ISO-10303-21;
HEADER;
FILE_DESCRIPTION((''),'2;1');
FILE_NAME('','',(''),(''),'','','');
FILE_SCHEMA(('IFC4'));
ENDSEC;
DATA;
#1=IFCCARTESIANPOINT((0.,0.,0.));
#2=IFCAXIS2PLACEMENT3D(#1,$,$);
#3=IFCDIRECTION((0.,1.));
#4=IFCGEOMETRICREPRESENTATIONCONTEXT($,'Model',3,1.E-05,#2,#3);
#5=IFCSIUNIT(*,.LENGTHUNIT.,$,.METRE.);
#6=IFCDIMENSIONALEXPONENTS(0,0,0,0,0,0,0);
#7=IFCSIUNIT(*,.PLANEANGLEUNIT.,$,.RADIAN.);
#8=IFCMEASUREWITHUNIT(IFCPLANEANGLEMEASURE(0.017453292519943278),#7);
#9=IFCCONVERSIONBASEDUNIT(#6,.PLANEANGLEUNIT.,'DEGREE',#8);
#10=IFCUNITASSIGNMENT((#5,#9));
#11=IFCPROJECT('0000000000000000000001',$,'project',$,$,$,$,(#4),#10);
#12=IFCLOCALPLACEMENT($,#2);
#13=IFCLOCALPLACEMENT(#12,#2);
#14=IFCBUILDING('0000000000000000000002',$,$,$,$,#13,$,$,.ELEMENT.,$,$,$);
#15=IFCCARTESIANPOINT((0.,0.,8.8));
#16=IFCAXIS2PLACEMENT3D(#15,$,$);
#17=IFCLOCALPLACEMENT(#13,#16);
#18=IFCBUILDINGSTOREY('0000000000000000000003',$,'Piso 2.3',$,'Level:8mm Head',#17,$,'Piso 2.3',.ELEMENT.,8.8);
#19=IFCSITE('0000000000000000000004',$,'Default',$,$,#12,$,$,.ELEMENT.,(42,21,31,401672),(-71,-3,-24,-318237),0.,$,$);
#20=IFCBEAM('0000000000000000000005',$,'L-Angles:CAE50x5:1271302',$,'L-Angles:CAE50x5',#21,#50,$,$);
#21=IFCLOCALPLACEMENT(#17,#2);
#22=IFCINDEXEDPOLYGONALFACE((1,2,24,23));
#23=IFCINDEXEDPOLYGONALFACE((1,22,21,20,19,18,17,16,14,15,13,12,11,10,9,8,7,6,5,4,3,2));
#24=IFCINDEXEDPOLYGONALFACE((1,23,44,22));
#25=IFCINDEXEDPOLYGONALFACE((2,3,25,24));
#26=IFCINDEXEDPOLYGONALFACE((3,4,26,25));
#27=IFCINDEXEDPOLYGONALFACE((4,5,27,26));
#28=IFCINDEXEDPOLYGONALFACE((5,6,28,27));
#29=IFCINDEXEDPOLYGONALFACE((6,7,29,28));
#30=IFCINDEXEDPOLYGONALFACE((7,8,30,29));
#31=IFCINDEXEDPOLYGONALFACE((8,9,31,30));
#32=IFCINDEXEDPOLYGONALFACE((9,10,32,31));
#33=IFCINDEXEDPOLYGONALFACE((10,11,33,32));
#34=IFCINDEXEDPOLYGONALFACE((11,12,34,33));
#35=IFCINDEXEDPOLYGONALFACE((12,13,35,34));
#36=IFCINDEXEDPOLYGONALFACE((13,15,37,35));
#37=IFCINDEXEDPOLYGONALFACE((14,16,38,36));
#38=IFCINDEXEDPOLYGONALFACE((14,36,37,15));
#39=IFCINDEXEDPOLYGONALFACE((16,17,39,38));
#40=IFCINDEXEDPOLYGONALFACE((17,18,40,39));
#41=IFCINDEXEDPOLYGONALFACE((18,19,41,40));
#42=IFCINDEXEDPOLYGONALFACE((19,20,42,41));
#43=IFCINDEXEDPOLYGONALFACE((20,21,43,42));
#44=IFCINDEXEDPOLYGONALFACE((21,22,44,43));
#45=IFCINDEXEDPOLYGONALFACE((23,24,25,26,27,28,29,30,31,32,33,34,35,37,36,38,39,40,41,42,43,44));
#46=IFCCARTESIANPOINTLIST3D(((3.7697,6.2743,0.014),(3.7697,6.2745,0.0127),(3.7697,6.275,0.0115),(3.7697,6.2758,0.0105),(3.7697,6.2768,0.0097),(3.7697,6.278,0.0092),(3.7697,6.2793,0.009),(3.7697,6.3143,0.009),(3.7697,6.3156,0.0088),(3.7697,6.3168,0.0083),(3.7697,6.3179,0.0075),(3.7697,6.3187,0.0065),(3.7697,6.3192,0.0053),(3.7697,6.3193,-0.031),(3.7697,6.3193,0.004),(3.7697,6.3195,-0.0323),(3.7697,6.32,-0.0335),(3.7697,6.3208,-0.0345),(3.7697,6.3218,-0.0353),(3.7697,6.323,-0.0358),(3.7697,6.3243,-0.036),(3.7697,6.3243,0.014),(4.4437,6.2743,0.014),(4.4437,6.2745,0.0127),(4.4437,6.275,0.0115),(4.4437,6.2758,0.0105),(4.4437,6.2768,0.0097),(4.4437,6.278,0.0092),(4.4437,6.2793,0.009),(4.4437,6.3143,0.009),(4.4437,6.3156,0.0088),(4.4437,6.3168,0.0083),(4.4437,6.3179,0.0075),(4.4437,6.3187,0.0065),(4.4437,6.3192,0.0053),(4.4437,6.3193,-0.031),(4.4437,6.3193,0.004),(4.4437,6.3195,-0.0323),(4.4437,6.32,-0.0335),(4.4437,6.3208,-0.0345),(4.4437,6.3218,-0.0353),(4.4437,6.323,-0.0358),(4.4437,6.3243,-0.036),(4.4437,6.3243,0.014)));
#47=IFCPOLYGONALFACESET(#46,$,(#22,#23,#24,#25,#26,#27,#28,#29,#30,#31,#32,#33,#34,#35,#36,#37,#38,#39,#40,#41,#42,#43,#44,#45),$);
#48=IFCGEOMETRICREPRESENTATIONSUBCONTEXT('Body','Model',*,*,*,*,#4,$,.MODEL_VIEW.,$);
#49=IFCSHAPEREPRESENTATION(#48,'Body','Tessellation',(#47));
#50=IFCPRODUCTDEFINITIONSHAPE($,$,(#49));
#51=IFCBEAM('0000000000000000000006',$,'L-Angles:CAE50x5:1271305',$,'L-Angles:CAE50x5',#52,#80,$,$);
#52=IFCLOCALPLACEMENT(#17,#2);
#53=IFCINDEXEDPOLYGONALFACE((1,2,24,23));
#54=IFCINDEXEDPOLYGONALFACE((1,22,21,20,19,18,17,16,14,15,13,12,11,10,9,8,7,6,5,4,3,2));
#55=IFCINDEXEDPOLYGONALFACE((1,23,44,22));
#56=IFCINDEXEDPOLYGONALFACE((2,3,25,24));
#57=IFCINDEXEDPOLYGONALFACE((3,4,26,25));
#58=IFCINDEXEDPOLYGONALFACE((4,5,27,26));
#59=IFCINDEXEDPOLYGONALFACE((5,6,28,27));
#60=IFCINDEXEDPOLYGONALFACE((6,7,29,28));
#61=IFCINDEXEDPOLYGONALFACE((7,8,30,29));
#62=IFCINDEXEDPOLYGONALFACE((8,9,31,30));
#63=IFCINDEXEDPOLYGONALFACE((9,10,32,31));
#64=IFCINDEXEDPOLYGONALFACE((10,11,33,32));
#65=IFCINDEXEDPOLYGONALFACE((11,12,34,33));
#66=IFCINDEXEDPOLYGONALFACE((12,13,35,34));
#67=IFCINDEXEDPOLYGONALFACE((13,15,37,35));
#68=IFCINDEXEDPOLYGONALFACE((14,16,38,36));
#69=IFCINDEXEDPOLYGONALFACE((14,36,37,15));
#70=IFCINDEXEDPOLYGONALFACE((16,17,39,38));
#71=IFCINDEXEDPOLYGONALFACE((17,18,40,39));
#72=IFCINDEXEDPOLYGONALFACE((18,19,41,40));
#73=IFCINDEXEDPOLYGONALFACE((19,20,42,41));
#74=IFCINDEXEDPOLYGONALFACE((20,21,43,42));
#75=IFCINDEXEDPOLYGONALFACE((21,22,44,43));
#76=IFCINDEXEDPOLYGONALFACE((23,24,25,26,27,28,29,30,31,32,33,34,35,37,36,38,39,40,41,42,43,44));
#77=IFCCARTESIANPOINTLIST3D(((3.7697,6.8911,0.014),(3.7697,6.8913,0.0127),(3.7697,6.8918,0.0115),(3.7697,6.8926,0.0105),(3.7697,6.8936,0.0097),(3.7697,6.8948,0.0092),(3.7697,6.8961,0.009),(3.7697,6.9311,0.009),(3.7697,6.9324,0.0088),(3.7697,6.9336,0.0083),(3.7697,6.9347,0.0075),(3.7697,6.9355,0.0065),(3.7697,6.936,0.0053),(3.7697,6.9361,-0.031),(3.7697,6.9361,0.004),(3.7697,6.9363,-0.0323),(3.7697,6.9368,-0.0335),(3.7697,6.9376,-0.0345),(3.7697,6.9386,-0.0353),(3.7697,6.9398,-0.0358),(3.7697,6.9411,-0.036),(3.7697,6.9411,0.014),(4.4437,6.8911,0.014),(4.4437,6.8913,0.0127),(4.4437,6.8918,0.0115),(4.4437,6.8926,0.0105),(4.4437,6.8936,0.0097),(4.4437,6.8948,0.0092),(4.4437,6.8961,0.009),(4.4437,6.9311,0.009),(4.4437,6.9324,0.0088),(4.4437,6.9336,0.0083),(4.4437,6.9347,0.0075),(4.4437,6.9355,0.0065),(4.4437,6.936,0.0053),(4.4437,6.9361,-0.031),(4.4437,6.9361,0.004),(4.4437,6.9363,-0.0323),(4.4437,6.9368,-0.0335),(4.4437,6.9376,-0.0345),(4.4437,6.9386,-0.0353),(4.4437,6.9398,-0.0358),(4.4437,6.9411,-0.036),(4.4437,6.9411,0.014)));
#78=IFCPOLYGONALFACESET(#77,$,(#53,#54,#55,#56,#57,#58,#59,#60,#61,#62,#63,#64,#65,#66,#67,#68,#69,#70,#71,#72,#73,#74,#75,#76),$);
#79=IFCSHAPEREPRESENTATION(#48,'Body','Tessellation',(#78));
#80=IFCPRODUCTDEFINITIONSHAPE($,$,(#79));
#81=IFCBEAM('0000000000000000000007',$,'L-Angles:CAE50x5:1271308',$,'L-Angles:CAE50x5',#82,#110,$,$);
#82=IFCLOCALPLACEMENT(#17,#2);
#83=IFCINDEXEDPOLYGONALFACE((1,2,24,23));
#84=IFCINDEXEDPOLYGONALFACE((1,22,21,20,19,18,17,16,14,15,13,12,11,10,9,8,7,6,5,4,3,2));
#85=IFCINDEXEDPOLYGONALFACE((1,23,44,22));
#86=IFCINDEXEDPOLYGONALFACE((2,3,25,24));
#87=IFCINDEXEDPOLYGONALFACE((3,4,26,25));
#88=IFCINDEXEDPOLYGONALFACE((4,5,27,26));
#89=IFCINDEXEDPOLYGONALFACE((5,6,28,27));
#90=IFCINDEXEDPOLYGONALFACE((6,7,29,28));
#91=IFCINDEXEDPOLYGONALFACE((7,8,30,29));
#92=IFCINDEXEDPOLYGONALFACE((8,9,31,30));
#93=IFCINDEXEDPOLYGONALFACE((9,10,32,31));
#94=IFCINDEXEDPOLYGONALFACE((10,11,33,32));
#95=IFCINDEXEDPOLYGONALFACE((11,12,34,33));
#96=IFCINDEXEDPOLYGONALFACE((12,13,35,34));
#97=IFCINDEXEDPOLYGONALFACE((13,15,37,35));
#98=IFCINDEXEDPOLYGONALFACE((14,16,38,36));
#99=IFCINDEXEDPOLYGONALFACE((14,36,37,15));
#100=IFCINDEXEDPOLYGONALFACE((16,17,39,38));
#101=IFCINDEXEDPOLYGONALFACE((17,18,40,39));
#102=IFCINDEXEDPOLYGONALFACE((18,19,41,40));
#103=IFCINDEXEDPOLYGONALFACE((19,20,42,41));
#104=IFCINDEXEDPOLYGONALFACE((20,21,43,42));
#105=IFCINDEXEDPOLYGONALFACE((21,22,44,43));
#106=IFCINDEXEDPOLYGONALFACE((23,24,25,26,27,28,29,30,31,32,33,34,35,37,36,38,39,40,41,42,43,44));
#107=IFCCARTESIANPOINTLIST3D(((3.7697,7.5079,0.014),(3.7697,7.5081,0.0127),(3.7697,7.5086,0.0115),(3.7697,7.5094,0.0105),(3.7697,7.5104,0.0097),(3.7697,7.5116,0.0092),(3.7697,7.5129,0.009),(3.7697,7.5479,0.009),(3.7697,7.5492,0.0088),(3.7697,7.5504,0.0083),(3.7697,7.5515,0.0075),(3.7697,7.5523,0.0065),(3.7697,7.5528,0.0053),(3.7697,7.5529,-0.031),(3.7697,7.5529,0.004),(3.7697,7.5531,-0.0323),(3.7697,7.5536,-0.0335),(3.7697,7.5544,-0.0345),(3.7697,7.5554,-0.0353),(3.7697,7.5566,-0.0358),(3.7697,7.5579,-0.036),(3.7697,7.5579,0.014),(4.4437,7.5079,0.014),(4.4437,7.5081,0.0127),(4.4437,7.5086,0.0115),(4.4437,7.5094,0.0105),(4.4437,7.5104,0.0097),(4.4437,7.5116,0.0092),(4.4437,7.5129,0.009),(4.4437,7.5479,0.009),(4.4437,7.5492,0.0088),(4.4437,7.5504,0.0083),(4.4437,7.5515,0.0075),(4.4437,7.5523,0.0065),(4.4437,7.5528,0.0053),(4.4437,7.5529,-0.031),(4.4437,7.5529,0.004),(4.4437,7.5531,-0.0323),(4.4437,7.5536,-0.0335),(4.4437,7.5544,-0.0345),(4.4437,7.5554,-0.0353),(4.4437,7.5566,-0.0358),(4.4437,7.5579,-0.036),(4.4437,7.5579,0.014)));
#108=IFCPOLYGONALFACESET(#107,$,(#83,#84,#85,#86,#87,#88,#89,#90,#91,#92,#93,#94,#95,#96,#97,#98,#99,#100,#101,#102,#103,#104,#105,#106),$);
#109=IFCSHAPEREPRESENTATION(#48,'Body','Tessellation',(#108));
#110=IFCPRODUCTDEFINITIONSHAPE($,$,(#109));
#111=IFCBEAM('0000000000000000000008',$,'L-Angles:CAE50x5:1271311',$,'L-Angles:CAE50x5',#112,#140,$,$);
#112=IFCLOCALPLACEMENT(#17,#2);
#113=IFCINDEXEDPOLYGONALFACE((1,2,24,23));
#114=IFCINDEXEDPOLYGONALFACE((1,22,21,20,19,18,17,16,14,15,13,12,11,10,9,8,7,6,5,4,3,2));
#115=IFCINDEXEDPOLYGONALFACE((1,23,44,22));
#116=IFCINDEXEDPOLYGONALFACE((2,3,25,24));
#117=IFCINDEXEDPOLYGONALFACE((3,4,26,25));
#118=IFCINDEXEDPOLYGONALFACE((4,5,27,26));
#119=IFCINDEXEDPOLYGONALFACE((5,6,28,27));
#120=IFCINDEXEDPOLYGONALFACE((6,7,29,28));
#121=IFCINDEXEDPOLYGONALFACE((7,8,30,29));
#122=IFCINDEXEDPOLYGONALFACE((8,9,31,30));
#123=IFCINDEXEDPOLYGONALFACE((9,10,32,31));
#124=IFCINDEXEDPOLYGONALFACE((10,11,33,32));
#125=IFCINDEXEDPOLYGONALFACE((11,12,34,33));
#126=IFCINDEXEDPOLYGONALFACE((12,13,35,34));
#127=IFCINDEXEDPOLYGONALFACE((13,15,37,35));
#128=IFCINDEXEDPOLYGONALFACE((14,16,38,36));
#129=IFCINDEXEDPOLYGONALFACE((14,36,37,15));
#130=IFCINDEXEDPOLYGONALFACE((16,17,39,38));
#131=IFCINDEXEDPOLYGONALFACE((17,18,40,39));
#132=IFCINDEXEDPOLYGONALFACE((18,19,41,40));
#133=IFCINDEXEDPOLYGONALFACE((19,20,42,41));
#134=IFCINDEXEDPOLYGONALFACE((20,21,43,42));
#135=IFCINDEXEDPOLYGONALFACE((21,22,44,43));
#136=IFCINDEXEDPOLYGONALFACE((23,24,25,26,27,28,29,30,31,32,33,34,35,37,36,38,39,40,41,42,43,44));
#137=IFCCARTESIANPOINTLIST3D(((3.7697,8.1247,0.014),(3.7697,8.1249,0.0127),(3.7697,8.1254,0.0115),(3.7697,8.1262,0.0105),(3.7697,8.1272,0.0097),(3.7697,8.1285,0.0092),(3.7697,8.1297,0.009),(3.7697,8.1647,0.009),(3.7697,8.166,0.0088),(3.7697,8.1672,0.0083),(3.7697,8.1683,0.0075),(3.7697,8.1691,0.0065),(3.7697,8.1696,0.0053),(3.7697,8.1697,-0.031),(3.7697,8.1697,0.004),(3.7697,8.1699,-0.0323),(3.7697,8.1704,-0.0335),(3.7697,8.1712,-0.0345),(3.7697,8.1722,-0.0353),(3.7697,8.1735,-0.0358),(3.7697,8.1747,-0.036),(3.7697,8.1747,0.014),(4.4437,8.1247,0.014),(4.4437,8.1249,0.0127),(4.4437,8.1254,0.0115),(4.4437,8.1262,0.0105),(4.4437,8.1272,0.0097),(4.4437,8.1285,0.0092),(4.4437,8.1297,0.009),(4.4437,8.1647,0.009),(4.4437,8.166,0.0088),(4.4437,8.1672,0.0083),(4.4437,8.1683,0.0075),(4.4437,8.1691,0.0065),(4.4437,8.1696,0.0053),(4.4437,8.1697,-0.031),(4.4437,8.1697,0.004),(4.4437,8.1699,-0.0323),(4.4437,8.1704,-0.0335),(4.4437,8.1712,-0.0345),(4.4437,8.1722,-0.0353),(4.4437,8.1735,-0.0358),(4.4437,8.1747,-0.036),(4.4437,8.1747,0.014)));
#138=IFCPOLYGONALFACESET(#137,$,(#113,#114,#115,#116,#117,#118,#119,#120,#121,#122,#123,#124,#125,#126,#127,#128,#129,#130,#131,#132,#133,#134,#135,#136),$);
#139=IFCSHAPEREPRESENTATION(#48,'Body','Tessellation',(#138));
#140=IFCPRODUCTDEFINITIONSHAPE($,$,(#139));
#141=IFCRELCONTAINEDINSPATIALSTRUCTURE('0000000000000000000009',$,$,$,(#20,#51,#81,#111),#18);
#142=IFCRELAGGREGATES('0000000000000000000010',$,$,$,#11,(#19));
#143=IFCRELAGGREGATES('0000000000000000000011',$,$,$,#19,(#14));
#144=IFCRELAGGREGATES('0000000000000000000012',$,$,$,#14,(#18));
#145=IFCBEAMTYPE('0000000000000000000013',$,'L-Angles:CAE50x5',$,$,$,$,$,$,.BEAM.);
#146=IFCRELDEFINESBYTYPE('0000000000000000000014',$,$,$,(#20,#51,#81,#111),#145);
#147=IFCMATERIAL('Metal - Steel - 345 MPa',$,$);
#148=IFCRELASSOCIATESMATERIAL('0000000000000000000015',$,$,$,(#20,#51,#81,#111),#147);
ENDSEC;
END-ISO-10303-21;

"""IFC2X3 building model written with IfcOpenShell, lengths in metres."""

from ifc_helpers import new_model, entity, si_unit, converted_unit, direction, frame, frame_2d, origin, place, context, subcontext, project, spatial, polyline, circle_curve, parameter, trimmed, segment, composite_curve, outline, extrude, material, type_object, element, save


model = new_model("IFC2X3")

# Units and contexts
model_context = context("Model", 3, precision=1e-05, world=origin(), true_north=direction((0.0, 1.0)))
body_context = subcontext(model_context, "Body", "Model", "MODEL_VIEW")
ifc_project = project(units=[si_unit("LENGTHUNIT", "METRE"), converted_unit("PLANEANGLEUNIT", "DEGREE", entity("IfcPlaneAngleMeasure", 0.017453292519943278), si_unit("PLANEANGLEUNIT", "RADIAN"), dimensions=[0, 0, 0, 0, 0, 0, 0])], contexts=[model_context])

# Site, building, storey
site_placement = place(None, origin())
site = spatial("IfcSite", under=ifc_project, at=site_placement, Name="Default", CompositionType="ELEMENT", RefLatitude=(42, 21, 31, 401672), RefLongitude=(-71, -3, -24, -318237), RefElevation=0.0)
building_placement = place(site_placement, origin())
building = spatial("IfcBuilding", under=site, at=building_placement, CompositionType="ELEMENT")
storey_placement = place(building_placement, frame((0.0, 0.0, 8.8)))
storey = spatial("IfcBuildingStorey", under=building, at=storey_placement, Name="Piso 2.3", ObjectType="Level:8mm Head", LongName="Piso 2.3", CompositionType="ELEMENT", Elevation=8.8)

# Shared definitions
ifc_material = material(Name="Metal - Steel - 345 MPa")

# Beams
beam_type_1 = type_object("IfcBeamType", Name="L-Angles:CAE50x5", PredefinedType="BEAM")
beam_1_placement = place(storey_placement, frame((3.7067, 6.3103, 0.0)))
element("IfcBeam", 1, at=beam_1_placement, inside=storey, type_object=beam_type_1, material=ifc_material, Name="L-Angles:CAE50x5:1271302", ObjectType="L-Angles:CAE50x5", context=body_context, shape_type="SweptSolid", body=[
    extrude(outline(composite_curve([segment(polyline([(-0.0336, -0.0164), (0.0164, -0.0164)]), True, "CONTINUOUS"), segment(polyline([(0.0164, -0.0164), (0.0164, 0.0336)]), True, "CONTINUOUS"), segment(trimmed(circle_curve(frame_2d((0.0164, 0.0286), x_axis=(0.0, 1.0)), 0.005), [parameter(0.0)], [parameter(90.0)], True, "PARAMETER"), True, "CONTINUOUS"), segment(polyline([(0.0114, 0.0286), (0.0114, -0.0064)]), True, "CONTINUOUS"), segment(trimmed(circle_curve(frame_2d((0.0064, -0.0064), x_axis=(1.0, 0.0)), 0.005), [parameter(270.0)], [parameter(0.0)], True, "PARAMETER"), False, "CONTINUOUS"), segment(polyline([(0.0064, -0.0114), (-0.0286, -0.0114)]), True, "CONTINUOUS"), segment(trimmed(circle_curve(frame_2d((-0.0286, -0.0164), x_axis=(0.0, 1.0)), 0.005), [parameter(0.0)], [parameter(90.0)], True, "PARAMETER"), True, "CONTINUOUS")], self_intersect=False)), frame((0.063, -0.0024, -0.0024), z_axis=(1.0, 0.0, 0.0), x_axis=(0.0, 0.0, 1.0)), (0.0, 0.0, 1.0), 0.674),
])
beam_2_placement = place(storey_placement, frame((3.7067, 6.9271, 0.0)))
element("IfcBeam", 2, at=beam_2_placement, inside=storey, type_object=beam_type_1, material=ifc_material, Name="L-Angles:CAE50x5:1271305", ObjectType="L-Angles:CAE50x5", context=body_context, shape_type="SweptSolid", body=[
    extrude(outline(composite_curve([segment(polyline([(-0.0336, -0.0164), (0.0164, -0.0164)]), True, "CONTINUOUS"), segment(polyline([(0.0164, -0.0164), (0.0164, 0.0336)]), True, "CONTINUOUS"), segment(trimmed(circle_curve(frame_2d((0.0164, 0.0286), x_axis=(0.0, 1.0)), 0.005), [parameter(0.0)], [parameter(90.0)], True, "PARAMETER"), True, "CONTINUOUS"), segment(polyline([(0.0114, 0.0286), (0.0114, -0.0064)]), True, "CONTINUOUS"), segment(trimmed(circle_curve(frame_2d((0.0064, -0.0064), x_axis=(1.0, 0.0)), 0.005), [parameter(270.0)], [parameter(0.0)], True, "PARAMETER"), False, "CONTINUOUS"), segment(polyline([(0.0064, -0.0114), (-0.0286, -0.0114)]), True, "CONTINUOUS"), segment(trimmed(circle_curve(frame_2d((-0.0286, -0.0164), x_axis=(0.0, 1.0)), 0.005), [parameter(0.0)], [parameter(90.0)], True, "PARAMETER"), True, "CONTINUOUS")], self_intersect=False)), frame((0.063, -0.0024, -0.0024), z_axis=(1.0, 0.0, 0.0), x_axis=(0.0, 0.0, 1.0)), (0.0, 0.0, 1.0), 0.674),
])
beam_3_placement = place(storey_placement, frame((3.7067, 7.5439, 0.0)))
element("IfcBeam", 3, at=beam_3_placement, inside=storey, type_object=beam_type_1, material=ifc_material, Name="L-Angles:CAE50x5:1271308", ObjectType="L-Angles:CAE50x5", context=body_context, shape_type="SweptSolid", body=[
    extrude(outline(composite_curve([segment(polyline([(-0.0336, -0.0164), (0.0164, -0.0164)]), True, "CONTINUOUS"), segment(polyline([(0.0164, -0.0164), (0.0164, 0.0336)]), True, "CONTINUOUS"), segment(trimmed(circle_curve(frame_2d((0.0164, 0.0286), x_axis=(0.0, 1.0)), 0.005), [parameter(0.0)], [parameter(90.0)], True, "PARAMETER"), True, "CONTINUOUS"), segment(polyline([(0.0114, 0.0286), (0.0114, -0.0064)]), True, "CONTINUOUS"), segment(trimmed(circle_curve(frame_2d((0.0064, -0.0064), x_axis=(1.0, 0.0)), 0.005), [parameter(270.0)], [parameter(0.0)], True, "PARAMETER"), False, "CONTINUOUS"), segment(polyline([(0.0064, -0.0114), (-0.0286, -0.0114)]), True, "CONTINUOUS"), segment(trimmed(circle_curve(frame_2d((-0.0286, -0.0164), x_axis=(0.0, 1.0)), 0.005), [parameter(0.0)], [parameter(90.0)], True, "PARAMETER"), True, "CONTINUOUS")], self_intersect=False)), frame((0.063, -0.0024, -0.0024), z_axis=(1.0, 0.0, 0.0), x_axis=(0.0, 0.0, 1.0)), (0.0, 0.0, 1.0), 0.674),
])
beam_4_placement = place(storey_placement, frame((3.7067, 8.1607, 0.0)))
element("IfcBeam", 4, at=beam_4_placement, inside=storey, type_object=beam_type_1, material=ifc_material, Name="L-Angles:CAE50x5:1271311", ObjectType="L-Angles:CAE50x5", context=body_context, shape_type="SweptSolid", body=[
    extrude(outline(composite_curve([segment(polyline([(-0.0336, -0.0164), (0.0164, -0.0164)]), True, "CONTINUOUS"), segment(polyline([(0.0164, -0.0164), (0.0164, 0.0336)]), True, "CONTINUOUS"), segment(trimmed(circle_curve(frame_2d((0.0164, 0.0286), x_axis=(0.0, 1.0)), 0.005), [parameter(0.0)], [parameter(90.0)], True, "PARAMETER"), True, "CONTINUOUS"), segment(polyline([(0.0114, 0.0286), (0.0114, -0.0064)]), True, "CONTINUOUS"), segment(trimmed(circle_curve(frame_2d((0.0064, -0.0064), x_axis=(1.0, 0.0)), 0.005), [parameter(270.0)], [parameter(0.0)], True, "PARAMETER"), False, "CONTINUOUS"), segment(polyline([(0.0064, -0.0114), (-0.0286, -0.0114)]), True, "CONTINUOUS"), segment(trimmed(circle_curve(frame_2d((-0.0286, -0.0164), x_axis=(0.0, 1.0)), 0.005), [parameter(0.0)], [parameter(90.0)], True, "PARAMETER"), True, "CONTINUOUS")], self_intersect=False)), frame((0.063, -0.0024, -0.0024), z_axis=(1.0, 0.0, 0.0), x_axis=(0.0, 0.0, 1.0)), (0.0, 0.0, 1.0), 0.674),
])

save(model, "model.ifc")
